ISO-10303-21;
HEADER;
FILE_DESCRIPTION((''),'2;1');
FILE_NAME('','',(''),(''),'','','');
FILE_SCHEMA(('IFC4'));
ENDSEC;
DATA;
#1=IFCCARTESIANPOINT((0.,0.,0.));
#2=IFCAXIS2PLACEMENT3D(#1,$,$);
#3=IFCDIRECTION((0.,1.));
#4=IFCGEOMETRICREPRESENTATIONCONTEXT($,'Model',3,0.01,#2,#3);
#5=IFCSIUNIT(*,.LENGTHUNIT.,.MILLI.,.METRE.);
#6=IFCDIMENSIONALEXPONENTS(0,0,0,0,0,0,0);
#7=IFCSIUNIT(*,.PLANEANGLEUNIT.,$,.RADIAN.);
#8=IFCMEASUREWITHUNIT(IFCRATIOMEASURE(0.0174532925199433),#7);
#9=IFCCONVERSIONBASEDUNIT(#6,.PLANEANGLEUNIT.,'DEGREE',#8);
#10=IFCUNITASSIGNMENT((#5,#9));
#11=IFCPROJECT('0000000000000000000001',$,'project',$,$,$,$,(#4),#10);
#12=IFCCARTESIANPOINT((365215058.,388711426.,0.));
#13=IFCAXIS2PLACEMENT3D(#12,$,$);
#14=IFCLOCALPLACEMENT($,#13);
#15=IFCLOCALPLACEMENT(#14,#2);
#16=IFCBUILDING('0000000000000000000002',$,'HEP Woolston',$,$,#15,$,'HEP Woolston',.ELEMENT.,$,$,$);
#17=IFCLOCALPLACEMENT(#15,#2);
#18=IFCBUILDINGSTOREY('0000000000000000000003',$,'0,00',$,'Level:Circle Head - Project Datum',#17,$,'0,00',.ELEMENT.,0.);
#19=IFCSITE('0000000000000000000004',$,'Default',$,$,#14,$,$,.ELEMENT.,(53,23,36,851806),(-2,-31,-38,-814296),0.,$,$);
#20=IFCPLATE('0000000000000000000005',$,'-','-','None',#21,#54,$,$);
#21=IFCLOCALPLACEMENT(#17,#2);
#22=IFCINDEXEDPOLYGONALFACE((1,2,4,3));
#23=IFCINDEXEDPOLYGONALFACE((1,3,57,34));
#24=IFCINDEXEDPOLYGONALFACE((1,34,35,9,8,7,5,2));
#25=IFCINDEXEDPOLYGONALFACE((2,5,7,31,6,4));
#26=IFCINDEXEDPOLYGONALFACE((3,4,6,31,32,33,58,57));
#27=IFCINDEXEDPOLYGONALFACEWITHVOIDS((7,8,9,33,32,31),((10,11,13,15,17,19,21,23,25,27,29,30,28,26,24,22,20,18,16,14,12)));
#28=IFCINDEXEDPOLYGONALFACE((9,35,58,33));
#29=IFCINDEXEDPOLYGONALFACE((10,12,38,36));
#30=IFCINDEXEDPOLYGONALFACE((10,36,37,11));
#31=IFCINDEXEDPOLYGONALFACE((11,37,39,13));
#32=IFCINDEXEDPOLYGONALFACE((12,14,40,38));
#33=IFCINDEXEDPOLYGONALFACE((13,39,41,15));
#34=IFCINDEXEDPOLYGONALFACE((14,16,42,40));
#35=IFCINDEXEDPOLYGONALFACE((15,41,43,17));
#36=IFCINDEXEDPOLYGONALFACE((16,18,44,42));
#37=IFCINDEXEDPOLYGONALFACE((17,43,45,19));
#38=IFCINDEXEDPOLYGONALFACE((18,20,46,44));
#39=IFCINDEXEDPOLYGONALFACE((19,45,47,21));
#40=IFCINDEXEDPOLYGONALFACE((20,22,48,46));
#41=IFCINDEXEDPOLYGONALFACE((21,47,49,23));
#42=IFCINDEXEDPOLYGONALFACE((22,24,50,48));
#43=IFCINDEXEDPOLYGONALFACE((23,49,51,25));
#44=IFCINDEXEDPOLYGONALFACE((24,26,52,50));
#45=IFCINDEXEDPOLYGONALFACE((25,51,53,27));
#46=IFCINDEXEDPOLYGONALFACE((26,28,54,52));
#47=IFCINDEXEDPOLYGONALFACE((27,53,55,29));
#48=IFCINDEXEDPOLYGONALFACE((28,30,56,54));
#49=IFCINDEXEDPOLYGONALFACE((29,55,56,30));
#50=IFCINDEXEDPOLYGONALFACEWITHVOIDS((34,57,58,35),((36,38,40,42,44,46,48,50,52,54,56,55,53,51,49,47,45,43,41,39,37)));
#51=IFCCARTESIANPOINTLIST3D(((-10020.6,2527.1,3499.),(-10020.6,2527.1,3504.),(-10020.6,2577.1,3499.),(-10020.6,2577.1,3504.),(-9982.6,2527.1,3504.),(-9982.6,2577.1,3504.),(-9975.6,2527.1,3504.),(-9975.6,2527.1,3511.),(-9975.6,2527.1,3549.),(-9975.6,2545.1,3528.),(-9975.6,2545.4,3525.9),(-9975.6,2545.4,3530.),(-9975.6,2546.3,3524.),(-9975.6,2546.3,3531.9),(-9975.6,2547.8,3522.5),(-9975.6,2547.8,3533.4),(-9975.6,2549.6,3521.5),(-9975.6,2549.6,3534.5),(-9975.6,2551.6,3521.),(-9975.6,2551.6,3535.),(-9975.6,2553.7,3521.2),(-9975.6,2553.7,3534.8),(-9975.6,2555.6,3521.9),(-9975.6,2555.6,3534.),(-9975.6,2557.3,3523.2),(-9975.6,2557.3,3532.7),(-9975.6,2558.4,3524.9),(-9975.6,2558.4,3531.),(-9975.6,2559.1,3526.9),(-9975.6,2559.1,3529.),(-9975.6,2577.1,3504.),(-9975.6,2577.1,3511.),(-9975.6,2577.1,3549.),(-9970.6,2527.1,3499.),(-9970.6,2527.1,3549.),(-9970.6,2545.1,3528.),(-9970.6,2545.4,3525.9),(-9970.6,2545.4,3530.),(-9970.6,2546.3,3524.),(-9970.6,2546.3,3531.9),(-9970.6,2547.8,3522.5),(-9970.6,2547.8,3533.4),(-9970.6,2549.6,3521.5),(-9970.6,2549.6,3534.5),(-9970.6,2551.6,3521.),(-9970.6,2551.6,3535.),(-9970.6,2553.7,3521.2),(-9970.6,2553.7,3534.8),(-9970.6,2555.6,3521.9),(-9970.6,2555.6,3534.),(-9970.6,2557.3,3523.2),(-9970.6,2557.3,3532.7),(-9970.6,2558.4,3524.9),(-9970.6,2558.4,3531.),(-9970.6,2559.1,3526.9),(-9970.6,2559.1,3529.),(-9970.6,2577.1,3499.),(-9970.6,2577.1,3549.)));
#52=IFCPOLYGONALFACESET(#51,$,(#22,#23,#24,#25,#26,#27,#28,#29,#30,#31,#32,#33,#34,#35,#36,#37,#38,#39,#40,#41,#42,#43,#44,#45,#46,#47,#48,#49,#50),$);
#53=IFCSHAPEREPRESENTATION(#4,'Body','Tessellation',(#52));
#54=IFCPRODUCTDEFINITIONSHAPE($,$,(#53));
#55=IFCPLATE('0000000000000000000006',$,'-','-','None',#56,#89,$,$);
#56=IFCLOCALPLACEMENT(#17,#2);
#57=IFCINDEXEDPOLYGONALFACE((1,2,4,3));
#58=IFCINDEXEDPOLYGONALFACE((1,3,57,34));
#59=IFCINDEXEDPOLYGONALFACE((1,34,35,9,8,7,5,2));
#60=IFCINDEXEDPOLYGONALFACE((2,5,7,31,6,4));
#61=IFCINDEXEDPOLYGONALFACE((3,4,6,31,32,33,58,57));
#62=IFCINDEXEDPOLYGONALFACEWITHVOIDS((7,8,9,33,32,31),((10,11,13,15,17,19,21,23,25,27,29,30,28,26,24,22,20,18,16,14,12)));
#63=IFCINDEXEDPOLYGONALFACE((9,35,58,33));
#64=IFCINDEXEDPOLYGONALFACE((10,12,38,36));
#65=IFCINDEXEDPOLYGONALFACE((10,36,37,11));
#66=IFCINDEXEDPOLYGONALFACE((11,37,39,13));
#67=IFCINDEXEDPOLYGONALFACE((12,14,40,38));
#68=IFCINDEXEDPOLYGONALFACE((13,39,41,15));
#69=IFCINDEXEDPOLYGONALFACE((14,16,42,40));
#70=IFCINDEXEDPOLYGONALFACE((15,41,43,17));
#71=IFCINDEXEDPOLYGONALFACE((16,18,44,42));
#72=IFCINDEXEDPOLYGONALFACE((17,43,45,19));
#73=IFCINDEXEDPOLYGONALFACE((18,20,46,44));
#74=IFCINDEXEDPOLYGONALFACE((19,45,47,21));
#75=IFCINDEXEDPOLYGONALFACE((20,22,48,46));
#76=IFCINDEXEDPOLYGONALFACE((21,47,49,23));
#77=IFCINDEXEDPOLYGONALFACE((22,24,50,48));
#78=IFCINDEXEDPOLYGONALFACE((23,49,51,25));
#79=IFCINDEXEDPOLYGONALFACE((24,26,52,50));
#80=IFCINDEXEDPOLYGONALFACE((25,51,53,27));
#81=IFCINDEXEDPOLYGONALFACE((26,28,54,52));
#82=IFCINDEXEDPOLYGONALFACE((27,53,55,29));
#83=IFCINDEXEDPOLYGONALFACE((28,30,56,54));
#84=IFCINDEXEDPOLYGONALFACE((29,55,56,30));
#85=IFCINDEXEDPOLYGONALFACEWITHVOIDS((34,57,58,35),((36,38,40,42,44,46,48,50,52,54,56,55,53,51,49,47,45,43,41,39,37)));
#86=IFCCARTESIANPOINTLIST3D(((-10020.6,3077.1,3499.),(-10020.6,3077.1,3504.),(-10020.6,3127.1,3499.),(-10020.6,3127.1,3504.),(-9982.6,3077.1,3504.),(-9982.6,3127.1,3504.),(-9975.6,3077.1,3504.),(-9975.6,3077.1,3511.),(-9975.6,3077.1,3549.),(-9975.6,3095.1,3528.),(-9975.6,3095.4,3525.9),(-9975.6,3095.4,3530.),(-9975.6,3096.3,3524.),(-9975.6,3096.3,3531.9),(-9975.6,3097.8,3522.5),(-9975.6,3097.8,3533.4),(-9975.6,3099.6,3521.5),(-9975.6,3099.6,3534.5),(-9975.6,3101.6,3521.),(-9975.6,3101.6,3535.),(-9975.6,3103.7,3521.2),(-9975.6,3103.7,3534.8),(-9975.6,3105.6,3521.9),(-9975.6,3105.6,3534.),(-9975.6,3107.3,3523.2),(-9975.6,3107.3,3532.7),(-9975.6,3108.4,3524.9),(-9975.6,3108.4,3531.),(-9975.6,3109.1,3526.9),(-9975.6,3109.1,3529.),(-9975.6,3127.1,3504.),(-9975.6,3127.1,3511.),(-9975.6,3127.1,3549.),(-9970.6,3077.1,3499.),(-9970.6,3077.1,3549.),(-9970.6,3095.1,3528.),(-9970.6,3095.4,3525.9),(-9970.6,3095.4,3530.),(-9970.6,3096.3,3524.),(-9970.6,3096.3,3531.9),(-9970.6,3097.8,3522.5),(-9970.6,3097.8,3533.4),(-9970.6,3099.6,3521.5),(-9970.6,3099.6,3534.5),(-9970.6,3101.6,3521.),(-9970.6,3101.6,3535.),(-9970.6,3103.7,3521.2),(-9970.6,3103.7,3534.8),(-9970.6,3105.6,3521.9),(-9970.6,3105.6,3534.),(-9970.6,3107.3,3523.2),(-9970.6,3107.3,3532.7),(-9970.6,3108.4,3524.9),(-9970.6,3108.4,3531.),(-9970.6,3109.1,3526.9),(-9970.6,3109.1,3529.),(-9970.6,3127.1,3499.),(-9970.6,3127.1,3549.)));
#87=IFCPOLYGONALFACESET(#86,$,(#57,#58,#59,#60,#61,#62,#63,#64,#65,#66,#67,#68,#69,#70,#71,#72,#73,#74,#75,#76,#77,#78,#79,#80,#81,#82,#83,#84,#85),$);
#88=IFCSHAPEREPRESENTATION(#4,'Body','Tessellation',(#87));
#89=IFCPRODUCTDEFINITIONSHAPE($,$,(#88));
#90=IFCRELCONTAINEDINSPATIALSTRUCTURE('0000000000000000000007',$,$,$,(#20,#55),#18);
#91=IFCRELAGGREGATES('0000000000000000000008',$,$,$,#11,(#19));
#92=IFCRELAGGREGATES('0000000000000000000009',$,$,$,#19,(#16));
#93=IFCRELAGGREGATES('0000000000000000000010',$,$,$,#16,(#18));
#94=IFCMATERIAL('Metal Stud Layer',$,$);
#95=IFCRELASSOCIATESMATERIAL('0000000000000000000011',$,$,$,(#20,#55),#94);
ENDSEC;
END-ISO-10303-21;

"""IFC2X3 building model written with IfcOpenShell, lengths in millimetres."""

from ifc_helpers import new_model, entity, si_unit, converted_unit, point, direction, frame, frame_2d, origin, origin_with_axes, origin_2d_with_axis, place, context, project, spatial, polyline, circle_curve, line_curve, trimmed, segment, composite_curve, circle, outline, extrude, material, element, save


model = new_model("IFC2X3")

# Units and contexts
model_context = context("Model", 3, precision=0.01, world=origin(), true_north=direction((0.0, 1.0)))
ifc_project = project(units=[si_unit("LENGTHUNIT", "METRE", prefix="MILLI"), converted_unit("PLANEANGLEUNIT", "DEGREE", entity("IfcRatioMeasure", 0.0174532925199433), si_unit("PLANEANGLEUNIT", "RADIAN"), dimensions=[0, 0, 0, 0, 0, 0, 0])], contexts=[model_context])

# Site, building, storey
site_placement = place(None, frame((365215058.0, 388711426.0, 0.0)))
site = spatial("IfcSite", under=ifc_project, at=site_placement, Name="Default", CompositionType="ELEMENT", RefLatitude=(53, 23, 36, 851806), RefLongitude=(-2, -31, -38, -814296), RefElevation=0.0)
building_placement = place(site_placement, origin())
building = spatial("IfcBuilding", under=site, at=building_placement, Name="HEP Woolston", LongName="HEP Woolston", CompositionType="ELEMENT")
storey_placement = place(building_placement, origin())
storey = spatial("IfcBuildingStorey", under=building, at=storey_placement, Name="0,00", ObjectType="Level:Circle Head - Project Datum", LongName="0,00", CompositionType="ELEMENT", Elevation=0.0)

# Plates, openings
ifc_material = material(Name="Metal Stud Layer")
plate_1_placement = place(storey_placement, frame((-9970.6, 2527.1, 3499.0), z_axis=(0.0, 1.0, 0.0), x_axis=(-1.0, 0.0, 0.0)))
plate_1 = element("IfcPlate", 1, at=plate_1_placement, inside=storey, material=ifc_material, Name="-", Description="-", ObjectType="None", context=model_context, shape_type="SweptSolid", body=[
    extrude(outline(polyline([(0.0, 0.0), (50.0, 0.0), (50.0, 5.0), (5.0, 5.0), (5.0, 50.0), (0.0, 50.0), (0.0, 0.0)])), origin_with_axes(), (0.0, 0.0, 1.0), 50.0),
])
opening_1_placement = place(plate_1_placement, frame((0.0, 0.0, 0.0), z_axis=(0.0, 0.0, 1.0), x_axis=(1.0, 0.0, 0.0)))
element("IfcOpeningElement", 2, at=opening_1_placement, cuts=plate_1, ObjectType="Opening", context=model_context, shape_type="SweptSolid", body=[
    extrude(outline(composite_curve([segment(trimmed(line_curve((50.0, 5.0), (1.0, 0.0), 3.532613), [point((50.0, 5.0))], [point((46.5, 5.0))], True, "CARTESIAN"), True, "CONTINUOUS"), segment(trimmed(circle_curve(frame_2d((46.5, 1.5), x_axis=(-1.0, 0.0)), 3.5), [point((46.5, 5.0))], [point((50.0, 1.5))], False, "CARTESIAN"), True, "CONTINUOUS"), segment(trimmed(line_curve((50.0, 1.5), (0.0, -1.0), 3.532613), [point((50.0, 1.5))], [point((50.0, 5.0))], True, "CARTESIAN"), True, "CONTINUOUS")], self_intersect="UNKNOWN")), origin(), (0.0, 0.0, 1.0), 50.0),
])
opening_2_placement = place(plate_1_placement, origin_with_axes())
element("IfcOpeningElement", 3, at=opening_2_placement, cuts=plate_1, ObjectType="Opening", context=model_context, shape_type="SweptSolid", body=[
    extrude(outline(composite_curve([segment(trimmed(line_curve((5.0, 5.0), (0.0, -1.0), 7.046301), [point((5.0, 5.0))], [point((5.0, 12.0))], False, "CARTESIAN"), True, "CONTINUOUS"), segment(trimmed(circle_curve(frame_2d((12.0, 12.0), x_axis=(1.0, 0.0)), 7.0), [point((5.0, 12.0))], [point((12.0, 5.0))], True, "CARTESIAN"), True, "CONTINUOUS"), segment(trimmed(line_curve((12.0, 5.0), (1.0, 0.0), 7.046301), [point((12.0, 5.0))], [point((5.0, 5.0))], False, "CARTESIAN"), True, "CONTINUOUS")], self_intersect="UNKNOWN")), origin(), (0.0, 0.0, 1.0), 50.0),
])
opening_3_placement = place(plate_1_placement, frame((0.0, 0.0, 0.0), z_axis=(0.0, 0.0, 1.0), x_axis=(1.0, 0.0, 0.0)))
element("IfcOpeningElement", 4, at=opening_3_placement, cuts=plate_1, ObjectType="Opening", context=model_context, shape_type="SweptSolid", body=[
    extrude(outline(composite_curve([segment(trimmed(line_curve((5.0, 50.0), (1.0, 0.0), 3.4874), [point((5.0, 50.0))], [point((1.5, 50.0))], True, "CARTESIAN"), True, "CONTINUOUS"), segment(trimmed(circle_curve(frame_2d((1.5, 46.5), x_axis=(-1.0, 0.0)), 3.5), [point((1.5, 50.0))], [point((5.0, 46.5))], False, "CARTESIAN"), True, "CONTINUOUS"), segment(trimmed(line_curve((5.0, 46.5), (0.0, -1.0), 3.4874), [point((5.0, 46.5))], [point((5.0, 50.0))], True, "CARTESIAN"), True, "CONTINUOUS")], self_intersect="UNKNOWN")), origin(), (0.0, 0.0, 1.0), 50.0),
])
opening_4_placement = place(plate_1_placement, frame((-0.5, 29.0, 25.0), z_axis=(1.0, 0.0, 0.0), x_axis=(0.0, 0.0, -1.0)))
element("IfcOpeningElement", 5, at=opening_4_placement, cuts=plate_1, ObjectType="Opening", context=model_context, shape_type="SweptSolid", body=[
    extrude(circle(Radius=7.0, at=origin_2d_with_axis()), origin(), (0.0, 0.0, 1.0), 6.0),
])
plate_2_placement = place(storey_placement, frame((-9970.6, 3077.1, 3499.0), z_axis=(0.0, 1.0, 0.0), x_axis=(-1.0, 0.0, 0.0)))
plate_2 = element("IfcPlate", 6, at=plate_2_placement, inside=storey, material=ifc_material, Name="-", Description="-", ObjectType="None", context=model_context, shape_type="SweptSolid", body=[
    extrude(outline(polyline([(0.0, 0.0), (50.0, 0.0), (50.0, 5.0), (5.0, 5.0), (5.0, 50.0), (0.0, 50.0), (0.0, 0.0)])), origin_with_axes(), (0.0, 0.0, 1.0), 50.0),
])
opening_5_placement = place(plate_2_placement, frame((0.0, 0.0, 0.0), z_axis=(0.0, 0.0, 1.0), x_axis=(1.0, 0.0, 0.0)))
element("IfcOpeningElement", 7, at=opening_5_placement, cuts=plate_2, ObjectType="Opening", context=model_context, shape_type="SweptSolid", body=[
    extrude(outline(composite_curve([segment(trimmed(line_curve((50.0, 5.0), (1.0, 0.0), 3.532613), [point((50.0, 5.0))], [point((46.5, 5.0))], True, "CARTESIAN"), True, "CONTINUOUS"), segment(trimmed(circle_curve(frame_2d((46.5, 1.5), x_axis=(-1.0, 0.0)), 3.5), [point((46.5, 5.0))], [point((50.0, 1.5))], False, "CARTESIAN"), True, "CONTINUOUS"), segment(trimmed(line_curve((50.0, 1.5), (0.0, -1.0), 3.532613), [point((50.0, 1.5))], [point((50.0, 5.0))], True, "CARTESIAN"), True, "CONTINUOUS")], self_intersect="UNKNOWN")), origin(), (0.0, 0.0, 1.0), 50.0),
])
opening_6_placement = place(plate_2_placement, origin_with_axes())
element("IfcOpeningElement", 8, at=opening_6_placement, cuts=plate_2, ObjectType="Opening", context=model_context, shape_type="SweptSolid", body=[
    extrude(outline(composite_curve([segment(trimmed(line_curve((5.0, 5.0), (0.0, -1.0), 7.046301), [point((5.0, 5.0))], [point((5.0, 12.0))], False, "CARTESIAN"), True, "CONTINUOUS"), segment(trimmed(circle_curve(frame_2d((12.0, 12.0), x_axis=(1.0, 0.0)), 7.0), [point((5.0, 12.0))], [point((12.0, 5.0))], True, "CARTESIAN"), True, "CONTINUOUS"), segment(trimmed(line_curve((12.0, 5.0), (1.0, 0.0), 7.046301), [point((12.0, 5.0))], [point((5.0, 5.0))], False, "CARTESIAN"), True, "CONTINUOUS")], self_intersect="UNKNOWN")), origin(), (0.0, 0.0, 1.0), 50.0),
])
opening_7_placement = place(plate_2_placement, frame((0.0, 0.0, 0.0), z_axis=(0.0, 0.0, 1.0), x_axis=(1.0, 0.0, 0.0)))
element("IfcOpeningElement", 9, at=opening_7_placement, cuts=plate_2, ObjectType="Opening", context=model_context, shape_type="SweptSolid", body=[
    extrude(outline(composite_curve([segment(trimmed(line_curve((5.0, 50.0), (1.0, 0.0), 3.4874), [point((5.0, 50.0))], [point((1.5, 50.0))], True, "CARTESIAN"), True, "CONTINUOUS"), segment(trimmed(circle_curve(frame_2d((1.5, 46.5), x_axis=(-1.0, 0.0)), 3.5), [point((1.5, 50.0))], [point((5.0, 46.5))], False, "CARTESIAN"), True, "CONTINUOUS"), segment(trimmed(line_curve((5.0, 46.5), (0.0, -1.0), 3.4874), [point((5.0, 46.5))], [point((5.0, 50.0))], True, "CARTESIAN"), True, "CONTINUOUS")], self_intersect="UNKNOWN")), origin(), (0.0, 0.0, 1.0), 50.0),
])
opening_8_placement = place(plate_2_placement, frame((-0.5, 29.0, 25.0), z_axis=(1.0, 0.0, 0.0), x_axis=(0.0, 0.0, -1.0)))
element("IfcOpeningElement", 10, at=opening_8_placement, cuts=plate_2, ObjectType="Opening", context=model_context, shape_type="SweptSolid", body=[
    extrude(circle(Radius=7.0, at=origin_2d_with_axis()), origin(), (0.0, 0.0, 1.0), 6.0),
])

save(model, "model.ifc")
